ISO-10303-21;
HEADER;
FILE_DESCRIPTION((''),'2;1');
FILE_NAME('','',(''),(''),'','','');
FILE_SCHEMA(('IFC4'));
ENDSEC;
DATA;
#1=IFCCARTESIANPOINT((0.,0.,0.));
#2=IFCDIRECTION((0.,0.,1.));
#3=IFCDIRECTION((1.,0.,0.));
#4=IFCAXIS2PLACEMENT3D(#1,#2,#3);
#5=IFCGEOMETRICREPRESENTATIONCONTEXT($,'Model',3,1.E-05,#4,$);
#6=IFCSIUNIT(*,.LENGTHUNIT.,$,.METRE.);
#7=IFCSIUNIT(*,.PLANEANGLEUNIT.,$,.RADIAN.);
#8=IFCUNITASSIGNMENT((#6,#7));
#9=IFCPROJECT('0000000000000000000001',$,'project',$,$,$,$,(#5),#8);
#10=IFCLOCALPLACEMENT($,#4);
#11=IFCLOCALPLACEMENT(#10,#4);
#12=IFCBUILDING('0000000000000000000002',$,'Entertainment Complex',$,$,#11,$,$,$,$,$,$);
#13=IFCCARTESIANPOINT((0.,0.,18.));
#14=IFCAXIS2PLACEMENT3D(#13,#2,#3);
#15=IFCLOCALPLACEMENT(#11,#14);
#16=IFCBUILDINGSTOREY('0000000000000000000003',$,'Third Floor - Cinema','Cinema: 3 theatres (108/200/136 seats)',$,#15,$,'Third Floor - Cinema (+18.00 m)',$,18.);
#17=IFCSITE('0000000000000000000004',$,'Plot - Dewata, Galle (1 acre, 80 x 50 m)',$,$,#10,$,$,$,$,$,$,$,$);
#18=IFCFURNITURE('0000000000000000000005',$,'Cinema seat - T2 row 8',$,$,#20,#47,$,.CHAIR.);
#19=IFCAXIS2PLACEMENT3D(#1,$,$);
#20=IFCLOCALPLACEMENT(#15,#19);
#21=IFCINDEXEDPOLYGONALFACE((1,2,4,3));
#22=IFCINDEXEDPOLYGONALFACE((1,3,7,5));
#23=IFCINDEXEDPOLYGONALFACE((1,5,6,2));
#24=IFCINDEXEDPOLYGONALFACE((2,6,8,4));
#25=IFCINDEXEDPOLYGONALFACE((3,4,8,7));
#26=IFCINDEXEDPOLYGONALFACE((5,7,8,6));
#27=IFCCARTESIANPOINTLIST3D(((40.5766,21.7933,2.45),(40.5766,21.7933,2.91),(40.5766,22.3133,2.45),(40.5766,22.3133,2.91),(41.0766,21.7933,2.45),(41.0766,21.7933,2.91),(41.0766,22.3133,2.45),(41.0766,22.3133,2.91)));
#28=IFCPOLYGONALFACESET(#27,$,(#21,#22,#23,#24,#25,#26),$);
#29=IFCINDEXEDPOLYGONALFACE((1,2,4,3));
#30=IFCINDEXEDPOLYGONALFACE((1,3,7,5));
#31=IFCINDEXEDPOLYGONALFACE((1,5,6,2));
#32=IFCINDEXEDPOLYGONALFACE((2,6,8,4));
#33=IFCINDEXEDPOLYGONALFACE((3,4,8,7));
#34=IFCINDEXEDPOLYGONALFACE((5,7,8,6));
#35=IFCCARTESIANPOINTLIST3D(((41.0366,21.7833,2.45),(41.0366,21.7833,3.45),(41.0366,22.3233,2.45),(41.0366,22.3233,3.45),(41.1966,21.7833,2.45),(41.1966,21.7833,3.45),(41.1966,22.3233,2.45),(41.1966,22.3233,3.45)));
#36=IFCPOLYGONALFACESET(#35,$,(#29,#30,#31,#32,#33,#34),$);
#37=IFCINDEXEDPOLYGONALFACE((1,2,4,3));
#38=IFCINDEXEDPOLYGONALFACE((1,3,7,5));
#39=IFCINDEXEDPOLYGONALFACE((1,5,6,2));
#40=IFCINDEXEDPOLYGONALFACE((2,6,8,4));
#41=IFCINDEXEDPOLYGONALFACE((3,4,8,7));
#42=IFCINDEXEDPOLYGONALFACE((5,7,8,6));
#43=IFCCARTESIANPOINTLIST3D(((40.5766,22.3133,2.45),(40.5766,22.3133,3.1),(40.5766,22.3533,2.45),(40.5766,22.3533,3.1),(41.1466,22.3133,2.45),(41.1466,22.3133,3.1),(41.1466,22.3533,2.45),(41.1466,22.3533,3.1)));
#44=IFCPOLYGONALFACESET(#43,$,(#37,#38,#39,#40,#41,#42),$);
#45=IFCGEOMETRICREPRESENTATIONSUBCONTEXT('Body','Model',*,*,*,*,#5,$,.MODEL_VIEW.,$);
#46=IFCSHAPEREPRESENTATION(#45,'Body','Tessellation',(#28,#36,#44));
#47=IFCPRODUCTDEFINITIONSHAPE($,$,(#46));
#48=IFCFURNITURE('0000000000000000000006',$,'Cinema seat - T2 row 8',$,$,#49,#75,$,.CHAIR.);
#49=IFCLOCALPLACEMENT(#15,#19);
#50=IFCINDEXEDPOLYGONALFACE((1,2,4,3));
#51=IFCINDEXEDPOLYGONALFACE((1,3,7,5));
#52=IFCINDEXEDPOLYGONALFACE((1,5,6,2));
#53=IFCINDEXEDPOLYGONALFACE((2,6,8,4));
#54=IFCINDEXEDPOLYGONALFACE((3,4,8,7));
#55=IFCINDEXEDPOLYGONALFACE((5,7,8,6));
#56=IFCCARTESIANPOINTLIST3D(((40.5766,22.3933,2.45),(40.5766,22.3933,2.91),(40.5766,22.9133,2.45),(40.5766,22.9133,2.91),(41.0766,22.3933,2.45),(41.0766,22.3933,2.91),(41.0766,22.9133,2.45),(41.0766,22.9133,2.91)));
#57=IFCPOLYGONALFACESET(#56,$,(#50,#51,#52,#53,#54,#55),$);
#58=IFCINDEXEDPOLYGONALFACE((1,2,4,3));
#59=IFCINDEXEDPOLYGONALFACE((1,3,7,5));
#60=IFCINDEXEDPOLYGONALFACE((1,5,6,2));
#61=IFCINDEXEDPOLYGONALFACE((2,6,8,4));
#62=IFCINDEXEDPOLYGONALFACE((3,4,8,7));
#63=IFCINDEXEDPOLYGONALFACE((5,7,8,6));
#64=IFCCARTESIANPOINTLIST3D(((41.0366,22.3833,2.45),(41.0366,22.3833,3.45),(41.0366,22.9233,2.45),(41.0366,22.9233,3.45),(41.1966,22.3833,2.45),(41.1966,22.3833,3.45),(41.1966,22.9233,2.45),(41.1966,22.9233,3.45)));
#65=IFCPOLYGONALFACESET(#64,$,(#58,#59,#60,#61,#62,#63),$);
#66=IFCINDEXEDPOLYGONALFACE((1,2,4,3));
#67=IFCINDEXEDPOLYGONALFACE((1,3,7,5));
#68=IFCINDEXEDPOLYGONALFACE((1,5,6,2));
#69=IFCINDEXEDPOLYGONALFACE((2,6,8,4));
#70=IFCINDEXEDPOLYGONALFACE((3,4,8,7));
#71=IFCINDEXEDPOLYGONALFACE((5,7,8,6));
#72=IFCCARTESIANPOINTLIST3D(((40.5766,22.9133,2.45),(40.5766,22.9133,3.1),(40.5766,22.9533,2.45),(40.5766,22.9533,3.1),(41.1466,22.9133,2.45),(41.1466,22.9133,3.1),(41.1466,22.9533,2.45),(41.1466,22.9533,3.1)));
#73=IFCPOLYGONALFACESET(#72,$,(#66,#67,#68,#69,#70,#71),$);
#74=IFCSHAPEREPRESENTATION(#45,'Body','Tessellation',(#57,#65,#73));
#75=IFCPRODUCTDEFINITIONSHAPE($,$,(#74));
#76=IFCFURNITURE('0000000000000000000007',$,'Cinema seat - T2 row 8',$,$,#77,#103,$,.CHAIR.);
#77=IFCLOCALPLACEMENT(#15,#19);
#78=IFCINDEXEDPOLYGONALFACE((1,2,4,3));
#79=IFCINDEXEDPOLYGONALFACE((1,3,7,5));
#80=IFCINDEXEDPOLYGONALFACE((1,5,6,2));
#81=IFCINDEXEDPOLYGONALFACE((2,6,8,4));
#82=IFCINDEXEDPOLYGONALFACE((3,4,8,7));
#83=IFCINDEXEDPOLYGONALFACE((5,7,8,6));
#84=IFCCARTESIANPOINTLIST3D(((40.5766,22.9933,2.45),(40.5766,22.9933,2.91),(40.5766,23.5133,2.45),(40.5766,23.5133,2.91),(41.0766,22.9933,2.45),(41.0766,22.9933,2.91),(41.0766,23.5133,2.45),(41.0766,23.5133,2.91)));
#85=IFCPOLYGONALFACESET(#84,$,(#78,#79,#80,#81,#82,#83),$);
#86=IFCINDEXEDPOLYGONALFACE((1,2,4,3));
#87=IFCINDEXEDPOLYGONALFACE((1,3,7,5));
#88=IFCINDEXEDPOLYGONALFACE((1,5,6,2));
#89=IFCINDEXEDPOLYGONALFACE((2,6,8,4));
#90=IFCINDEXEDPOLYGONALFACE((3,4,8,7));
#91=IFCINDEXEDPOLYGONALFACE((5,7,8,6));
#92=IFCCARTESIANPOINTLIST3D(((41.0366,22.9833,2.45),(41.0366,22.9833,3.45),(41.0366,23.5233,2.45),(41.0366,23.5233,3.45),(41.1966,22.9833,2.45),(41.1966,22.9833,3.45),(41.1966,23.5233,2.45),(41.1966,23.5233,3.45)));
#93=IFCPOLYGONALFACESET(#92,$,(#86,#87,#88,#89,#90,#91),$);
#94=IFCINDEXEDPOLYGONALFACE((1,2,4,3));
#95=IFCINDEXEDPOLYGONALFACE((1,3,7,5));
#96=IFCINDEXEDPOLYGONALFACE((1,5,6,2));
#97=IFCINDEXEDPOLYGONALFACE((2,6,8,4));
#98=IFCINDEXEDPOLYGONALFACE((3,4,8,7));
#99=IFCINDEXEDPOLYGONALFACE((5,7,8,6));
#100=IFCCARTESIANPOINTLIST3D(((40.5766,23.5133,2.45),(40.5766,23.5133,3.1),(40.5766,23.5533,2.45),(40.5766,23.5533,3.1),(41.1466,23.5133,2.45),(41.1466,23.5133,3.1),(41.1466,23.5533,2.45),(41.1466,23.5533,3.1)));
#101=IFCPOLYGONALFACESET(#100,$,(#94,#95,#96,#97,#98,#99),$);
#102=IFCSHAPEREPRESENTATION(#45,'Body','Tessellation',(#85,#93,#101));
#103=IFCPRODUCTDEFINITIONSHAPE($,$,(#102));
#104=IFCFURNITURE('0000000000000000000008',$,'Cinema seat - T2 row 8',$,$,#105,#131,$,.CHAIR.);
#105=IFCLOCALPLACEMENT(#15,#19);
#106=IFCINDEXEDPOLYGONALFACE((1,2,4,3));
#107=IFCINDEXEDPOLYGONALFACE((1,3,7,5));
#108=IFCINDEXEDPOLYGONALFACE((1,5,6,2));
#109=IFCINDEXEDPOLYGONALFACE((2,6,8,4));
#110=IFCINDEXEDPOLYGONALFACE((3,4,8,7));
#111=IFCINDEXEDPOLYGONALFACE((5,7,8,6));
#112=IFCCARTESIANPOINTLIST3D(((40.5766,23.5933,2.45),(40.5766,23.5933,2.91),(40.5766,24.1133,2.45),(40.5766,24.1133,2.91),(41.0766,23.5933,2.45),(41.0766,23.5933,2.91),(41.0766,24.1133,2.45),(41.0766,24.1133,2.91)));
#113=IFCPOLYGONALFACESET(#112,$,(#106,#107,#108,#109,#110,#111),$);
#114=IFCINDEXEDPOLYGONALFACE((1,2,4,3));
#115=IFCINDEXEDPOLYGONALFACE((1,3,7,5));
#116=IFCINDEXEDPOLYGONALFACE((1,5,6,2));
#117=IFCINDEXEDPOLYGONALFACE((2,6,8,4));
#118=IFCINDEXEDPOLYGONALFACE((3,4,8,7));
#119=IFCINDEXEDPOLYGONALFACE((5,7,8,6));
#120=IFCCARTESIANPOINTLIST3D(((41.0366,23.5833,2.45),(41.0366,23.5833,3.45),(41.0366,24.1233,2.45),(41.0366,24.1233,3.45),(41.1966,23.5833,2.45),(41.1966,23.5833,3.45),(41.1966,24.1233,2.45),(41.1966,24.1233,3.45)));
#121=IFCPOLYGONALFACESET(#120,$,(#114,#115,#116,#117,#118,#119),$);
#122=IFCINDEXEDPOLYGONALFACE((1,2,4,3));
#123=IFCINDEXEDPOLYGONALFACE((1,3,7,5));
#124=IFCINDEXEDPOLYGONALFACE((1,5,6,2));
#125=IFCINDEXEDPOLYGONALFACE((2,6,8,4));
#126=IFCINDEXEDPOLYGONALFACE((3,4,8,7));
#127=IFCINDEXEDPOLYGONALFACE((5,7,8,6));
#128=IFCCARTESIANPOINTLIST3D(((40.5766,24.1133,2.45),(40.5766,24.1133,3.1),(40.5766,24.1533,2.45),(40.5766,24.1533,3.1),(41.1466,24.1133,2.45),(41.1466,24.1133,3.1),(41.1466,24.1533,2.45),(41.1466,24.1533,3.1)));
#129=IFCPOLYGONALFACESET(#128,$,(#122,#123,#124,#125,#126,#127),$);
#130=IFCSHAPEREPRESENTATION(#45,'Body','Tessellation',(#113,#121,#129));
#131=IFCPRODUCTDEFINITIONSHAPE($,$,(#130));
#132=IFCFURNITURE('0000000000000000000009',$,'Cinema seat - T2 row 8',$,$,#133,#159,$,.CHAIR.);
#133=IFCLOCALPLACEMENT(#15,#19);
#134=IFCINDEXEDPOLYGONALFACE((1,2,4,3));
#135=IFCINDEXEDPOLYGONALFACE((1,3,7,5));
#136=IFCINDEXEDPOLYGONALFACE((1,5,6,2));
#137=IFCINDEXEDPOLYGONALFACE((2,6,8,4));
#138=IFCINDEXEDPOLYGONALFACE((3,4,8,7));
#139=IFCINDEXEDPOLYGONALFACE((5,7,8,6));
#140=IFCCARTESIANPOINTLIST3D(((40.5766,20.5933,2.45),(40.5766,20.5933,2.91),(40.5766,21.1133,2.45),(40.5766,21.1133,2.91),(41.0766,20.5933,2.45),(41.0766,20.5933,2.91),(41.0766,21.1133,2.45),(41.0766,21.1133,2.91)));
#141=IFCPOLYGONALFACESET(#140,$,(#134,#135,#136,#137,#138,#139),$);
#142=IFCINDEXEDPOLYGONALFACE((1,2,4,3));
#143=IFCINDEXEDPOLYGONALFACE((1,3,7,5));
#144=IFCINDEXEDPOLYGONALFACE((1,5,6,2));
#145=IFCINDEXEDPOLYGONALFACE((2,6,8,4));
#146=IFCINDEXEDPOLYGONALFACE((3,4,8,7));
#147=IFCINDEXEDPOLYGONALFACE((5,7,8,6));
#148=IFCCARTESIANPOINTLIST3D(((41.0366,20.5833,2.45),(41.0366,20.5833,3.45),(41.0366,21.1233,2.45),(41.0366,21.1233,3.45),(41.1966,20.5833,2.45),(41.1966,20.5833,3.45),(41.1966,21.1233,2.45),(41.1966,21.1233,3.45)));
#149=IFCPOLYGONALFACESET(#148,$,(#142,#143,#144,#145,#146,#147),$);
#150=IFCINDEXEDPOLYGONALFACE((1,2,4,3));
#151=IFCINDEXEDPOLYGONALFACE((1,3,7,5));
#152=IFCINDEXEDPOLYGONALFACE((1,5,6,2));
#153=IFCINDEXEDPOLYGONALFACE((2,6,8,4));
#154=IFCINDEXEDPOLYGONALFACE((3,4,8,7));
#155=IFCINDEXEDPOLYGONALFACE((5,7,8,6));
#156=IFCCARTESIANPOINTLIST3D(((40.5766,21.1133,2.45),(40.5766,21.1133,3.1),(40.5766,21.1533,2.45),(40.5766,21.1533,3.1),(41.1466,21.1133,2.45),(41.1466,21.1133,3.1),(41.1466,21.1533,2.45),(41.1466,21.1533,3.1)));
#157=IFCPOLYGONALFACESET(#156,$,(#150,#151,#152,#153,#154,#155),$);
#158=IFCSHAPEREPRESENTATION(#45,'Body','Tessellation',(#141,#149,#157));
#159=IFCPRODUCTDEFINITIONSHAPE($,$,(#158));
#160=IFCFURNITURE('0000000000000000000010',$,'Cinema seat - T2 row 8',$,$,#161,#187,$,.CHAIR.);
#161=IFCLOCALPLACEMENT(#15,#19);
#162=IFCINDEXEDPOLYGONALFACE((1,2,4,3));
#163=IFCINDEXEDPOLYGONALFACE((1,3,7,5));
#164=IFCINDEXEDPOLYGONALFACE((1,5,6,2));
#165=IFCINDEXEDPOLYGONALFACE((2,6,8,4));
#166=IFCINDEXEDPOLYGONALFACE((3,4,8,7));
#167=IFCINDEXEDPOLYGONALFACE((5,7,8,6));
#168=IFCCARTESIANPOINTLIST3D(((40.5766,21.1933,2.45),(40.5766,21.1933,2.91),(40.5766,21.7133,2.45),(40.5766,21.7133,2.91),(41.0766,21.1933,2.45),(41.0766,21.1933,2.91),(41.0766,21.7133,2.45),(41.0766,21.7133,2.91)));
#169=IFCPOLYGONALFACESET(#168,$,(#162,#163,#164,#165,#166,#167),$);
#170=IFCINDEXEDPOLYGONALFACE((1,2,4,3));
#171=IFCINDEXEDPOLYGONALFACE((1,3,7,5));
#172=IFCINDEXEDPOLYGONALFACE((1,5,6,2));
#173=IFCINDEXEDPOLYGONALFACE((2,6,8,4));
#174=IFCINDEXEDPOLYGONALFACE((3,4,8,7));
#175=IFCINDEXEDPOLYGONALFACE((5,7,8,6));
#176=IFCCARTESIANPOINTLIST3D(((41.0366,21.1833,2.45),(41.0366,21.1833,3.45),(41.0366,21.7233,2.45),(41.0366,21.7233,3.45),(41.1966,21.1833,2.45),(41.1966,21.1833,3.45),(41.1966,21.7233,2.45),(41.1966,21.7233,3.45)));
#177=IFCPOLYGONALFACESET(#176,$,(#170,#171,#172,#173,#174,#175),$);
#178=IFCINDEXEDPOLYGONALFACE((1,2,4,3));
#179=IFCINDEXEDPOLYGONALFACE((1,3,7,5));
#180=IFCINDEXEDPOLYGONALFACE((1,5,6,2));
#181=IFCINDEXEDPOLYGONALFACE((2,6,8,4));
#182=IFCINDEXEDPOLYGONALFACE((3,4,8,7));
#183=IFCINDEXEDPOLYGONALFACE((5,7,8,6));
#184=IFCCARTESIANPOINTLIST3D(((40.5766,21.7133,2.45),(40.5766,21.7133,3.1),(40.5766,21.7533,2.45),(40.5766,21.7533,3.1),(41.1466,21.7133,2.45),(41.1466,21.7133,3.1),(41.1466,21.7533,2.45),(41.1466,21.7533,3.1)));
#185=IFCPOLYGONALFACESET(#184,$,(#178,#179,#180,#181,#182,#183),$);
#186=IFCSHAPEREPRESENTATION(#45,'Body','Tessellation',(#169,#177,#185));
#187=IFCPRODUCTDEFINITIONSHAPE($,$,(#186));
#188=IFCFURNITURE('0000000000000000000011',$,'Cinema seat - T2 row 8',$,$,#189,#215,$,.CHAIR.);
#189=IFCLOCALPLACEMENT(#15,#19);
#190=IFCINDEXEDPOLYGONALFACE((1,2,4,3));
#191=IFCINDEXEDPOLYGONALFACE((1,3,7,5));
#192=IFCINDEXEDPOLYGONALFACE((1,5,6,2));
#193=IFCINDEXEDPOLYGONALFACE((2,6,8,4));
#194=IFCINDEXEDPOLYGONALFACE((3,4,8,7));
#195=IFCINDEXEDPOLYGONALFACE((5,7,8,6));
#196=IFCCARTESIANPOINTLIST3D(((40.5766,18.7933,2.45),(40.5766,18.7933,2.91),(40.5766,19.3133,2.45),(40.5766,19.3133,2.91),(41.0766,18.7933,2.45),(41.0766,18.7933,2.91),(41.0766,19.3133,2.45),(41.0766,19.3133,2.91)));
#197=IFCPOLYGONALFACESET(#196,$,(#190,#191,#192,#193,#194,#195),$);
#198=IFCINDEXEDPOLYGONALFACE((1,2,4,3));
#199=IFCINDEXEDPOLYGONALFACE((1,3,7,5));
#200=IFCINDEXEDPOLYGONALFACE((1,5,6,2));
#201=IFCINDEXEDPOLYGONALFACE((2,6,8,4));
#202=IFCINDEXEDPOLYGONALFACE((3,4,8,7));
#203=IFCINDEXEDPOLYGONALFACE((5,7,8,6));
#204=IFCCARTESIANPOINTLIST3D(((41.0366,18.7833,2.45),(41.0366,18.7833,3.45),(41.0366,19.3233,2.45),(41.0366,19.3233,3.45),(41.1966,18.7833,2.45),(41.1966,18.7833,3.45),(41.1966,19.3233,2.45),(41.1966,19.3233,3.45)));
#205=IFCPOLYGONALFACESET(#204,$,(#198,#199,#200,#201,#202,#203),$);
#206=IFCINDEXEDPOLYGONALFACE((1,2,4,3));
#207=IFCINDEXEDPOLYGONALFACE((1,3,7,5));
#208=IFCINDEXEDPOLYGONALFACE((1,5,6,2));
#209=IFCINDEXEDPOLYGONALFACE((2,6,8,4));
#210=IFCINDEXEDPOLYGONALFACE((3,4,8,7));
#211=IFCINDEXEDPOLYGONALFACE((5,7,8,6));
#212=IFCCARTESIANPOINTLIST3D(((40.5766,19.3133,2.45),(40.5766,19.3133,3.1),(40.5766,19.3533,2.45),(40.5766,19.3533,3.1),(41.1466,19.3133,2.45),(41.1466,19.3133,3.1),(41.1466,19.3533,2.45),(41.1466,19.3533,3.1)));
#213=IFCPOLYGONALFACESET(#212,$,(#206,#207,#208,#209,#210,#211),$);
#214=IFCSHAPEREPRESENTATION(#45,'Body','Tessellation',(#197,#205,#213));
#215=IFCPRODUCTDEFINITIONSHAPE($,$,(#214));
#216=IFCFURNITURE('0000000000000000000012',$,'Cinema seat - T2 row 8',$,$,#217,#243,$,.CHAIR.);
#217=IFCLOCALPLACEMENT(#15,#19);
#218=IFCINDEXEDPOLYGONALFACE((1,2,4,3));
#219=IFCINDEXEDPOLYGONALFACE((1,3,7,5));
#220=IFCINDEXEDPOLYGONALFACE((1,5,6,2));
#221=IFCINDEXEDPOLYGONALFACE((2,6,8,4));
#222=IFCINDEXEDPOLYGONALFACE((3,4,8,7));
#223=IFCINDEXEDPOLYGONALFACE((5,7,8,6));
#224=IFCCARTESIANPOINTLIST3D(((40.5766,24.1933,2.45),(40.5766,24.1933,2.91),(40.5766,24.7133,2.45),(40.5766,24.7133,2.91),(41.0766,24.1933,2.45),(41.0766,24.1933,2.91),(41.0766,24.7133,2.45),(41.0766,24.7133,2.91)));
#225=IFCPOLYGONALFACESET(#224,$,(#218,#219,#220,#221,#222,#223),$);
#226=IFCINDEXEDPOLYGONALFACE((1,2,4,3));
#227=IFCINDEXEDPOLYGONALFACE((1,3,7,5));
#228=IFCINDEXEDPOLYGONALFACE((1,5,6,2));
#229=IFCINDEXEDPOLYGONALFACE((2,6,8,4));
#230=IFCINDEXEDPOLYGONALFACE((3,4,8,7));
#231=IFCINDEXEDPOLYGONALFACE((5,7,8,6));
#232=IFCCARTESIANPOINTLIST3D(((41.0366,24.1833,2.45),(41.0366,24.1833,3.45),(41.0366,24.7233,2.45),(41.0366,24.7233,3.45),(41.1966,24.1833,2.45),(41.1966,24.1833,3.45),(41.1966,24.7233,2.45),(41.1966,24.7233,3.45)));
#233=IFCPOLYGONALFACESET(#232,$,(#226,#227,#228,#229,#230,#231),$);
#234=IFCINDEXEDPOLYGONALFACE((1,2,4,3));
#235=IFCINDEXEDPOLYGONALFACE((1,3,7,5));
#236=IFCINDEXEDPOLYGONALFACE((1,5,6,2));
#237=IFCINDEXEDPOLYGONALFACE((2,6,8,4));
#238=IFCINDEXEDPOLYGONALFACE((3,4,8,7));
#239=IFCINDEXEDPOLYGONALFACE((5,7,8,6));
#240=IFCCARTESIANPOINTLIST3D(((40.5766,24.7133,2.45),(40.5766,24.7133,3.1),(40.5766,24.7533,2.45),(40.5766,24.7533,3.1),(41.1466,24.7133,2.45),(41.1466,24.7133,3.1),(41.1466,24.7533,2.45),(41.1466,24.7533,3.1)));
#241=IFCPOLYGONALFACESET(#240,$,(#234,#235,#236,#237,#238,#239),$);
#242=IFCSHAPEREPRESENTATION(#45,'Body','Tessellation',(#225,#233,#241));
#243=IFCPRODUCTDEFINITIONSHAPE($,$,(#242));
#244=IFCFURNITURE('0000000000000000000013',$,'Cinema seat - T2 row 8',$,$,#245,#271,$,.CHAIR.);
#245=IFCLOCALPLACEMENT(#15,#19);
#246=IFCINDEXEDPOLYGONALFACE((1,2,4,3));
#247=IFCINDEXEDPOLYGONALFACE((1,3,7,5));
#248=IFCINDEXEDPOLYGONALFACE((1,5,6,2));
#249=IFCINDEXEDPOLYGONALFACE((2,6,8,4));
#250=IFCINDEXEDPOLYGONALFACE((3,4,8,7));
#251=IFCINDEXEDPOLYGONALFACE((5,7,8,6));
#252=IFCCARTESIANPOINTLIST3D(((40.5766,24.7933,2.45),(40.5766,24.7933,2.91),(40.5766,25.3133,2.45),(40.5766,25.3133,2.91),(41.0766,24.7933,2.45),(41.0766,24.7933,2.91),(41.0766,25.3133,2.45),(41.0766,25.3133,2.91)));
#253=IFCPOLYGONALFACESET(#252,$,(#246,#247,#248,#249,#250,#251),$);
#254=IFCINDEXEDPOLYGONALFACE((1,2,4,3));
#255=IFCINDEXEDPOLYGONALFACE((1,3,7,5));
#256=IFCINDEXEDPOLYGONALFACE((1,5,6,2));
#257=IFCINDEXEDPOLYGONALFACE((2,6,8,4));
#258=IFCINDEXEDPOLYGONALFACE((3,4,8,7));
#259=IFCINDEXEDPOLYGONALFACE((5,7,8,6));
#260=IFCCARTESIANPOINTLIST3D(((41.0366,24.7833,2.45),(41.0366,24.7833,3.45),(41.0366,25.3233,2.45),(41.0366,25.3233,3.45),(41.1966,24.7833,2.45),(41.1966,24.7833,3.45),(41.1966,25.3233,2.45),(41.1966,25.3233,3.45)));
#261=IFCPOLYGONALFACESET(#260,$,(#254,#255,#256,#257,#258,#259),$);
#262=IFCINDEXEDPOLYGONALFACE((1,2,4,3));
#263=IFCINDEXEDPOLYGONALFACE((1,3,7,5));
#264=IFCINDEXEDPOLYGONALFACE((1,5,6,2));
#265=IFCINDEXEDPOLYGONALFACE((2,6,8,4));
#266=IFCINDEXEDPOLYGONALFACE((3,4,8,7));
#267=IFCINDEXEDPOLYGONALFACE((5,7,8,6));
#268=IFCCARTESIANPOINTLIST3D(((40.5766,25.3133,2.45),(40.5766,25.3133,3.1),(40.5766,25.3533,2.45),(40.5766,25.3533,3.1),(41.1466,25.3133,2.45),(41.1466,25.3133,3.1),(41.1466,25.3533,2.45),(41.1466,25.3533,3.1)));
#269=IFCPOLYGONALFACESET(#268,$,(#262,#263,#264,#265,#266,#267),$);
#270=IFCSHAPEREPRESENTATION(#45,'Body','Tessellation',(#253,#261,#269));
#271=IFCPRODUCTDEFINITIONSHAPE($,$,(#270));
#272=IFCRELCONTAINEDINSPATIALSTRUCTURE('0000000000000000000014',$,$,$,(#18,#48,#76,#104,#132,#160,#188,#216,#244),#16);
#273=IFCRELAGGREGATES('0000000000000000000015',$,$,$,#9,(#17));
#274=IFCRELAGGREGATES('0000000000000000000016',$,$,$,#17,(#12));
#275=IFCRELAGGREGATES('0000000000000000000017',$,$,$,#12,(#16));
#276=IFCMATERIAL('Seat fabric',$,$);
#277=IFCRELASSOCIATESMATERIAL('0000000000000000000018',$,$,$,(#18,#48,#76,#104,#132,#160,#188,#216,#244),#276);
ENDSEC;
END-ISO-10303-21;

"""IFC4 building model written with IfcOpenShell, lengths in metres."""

from ifc_helpers import new_model, si_unit, frame, origin_with_axes, place, context, subcontext, project, spatial, polyline, outline, extrude, material, element, save


model = new_model("IFC4")

# Units and contexts
model_context = context("Model", 3, precision=1e-05, world=origin_with_axes())
body_context = subcontext(model_context, "Body", "Model", "MODEL_VIEW")
ifc_project = project(units=[si_unit("LENGTHUNIT", "METRE"), si_unit("PLANEANGLEUNIT", "RADIAN")], contexts=[model_context])

# Site, building, storey
site_placement = place(None, origin_with_axes())
site = spatial("IfcSite", under=ifc_project, at=site_placement, Name="Plot - Dewata, Galle (1 acre, 80 x 50 m)")
building_placement = place(site_placement, origin_with_axes())
building = spatial("IfcBuilding", under=site, at=building_placement, Name="Entertainment Complex")
storey_placement = place(building_placement, frame((0.0, 0.0, 18.0), z_axis=(0.0, 0.0, 1.0), x_axis=(1.0, 0.0, 0.0)))
storey = spatial("IfcBuildingStorey", under=building, at=storey_placement, Name="Third Floor - Cinema", Description="Cinema: 3 theatres (108/200/136 seats)", LongName="Third Floor - Cinema (+18.00 m)", Elevation=18.0)

# Furniture
ifc_material_1 = material(Name="Seat fabric")
for number, where, z_axis, x_axis, name in (
    (1, (41.1966, 22.0533, 2.45), (0.0, 0.0, 1.0), (1.0, 0.0, 0.0), "Cinema seat - T2 row 8"),
    (2, (41.1966, 22.6533, 2.45), (0.0, 0.0, 1.0), (1.0, 0.0, 0.0), "Cinema seat - T2 row 8"),
    (3, (41.1966, 23.2533, 2.45), (0.0, 0.0, 1.0), (1.0, 0.0, 0.0), "Cinema seat - T2 row 8"),
    (4, (41.1966, 23.8533, 2.45), (0.0, 0.0, 1.0), (1.0, 0.0, 0.0), "Cinema seat - T2 row 8"),
    (5, (41.1966, 20.8533, 2.45), (0.0, 0.0, 1.0), (1.0, 0.0, 0.0), "Cinema seat - T2 row 8"),
    (6, (41.1966, 21.4533, 2.45), (0.0, 0.0, 1.0), (1.0, 0.0, 0.0), "Cinema seat - T2 row 8"),
    (7, (41.1966, 19.0533, 2.45), (0.0, 0.0, 1.0), (1.0, 0.0, 0.0), "Cinema seat - T2 row 8"),
    (8, (41.1966, 24.4533, 2.45), (0.0, 0.0, 1.0), (1.0, 0.0, 0.0), "Cinema seat - T2 row 8"),
    (9, (41.1966, 25.0533, 2.45), (0.0, 0.0, 1.0), (1.0, 0.0, 0.0), "Cinema seat - T2 row 8"),
):
    element("IfcFurniture", number, at=place(storey_placement, frame(where, z_axis=z_axis, x_axis=x_axis)), inside=storey, material=ifc_material_1, Name=name, PredefinedType="CHAIR", context=body_context, shape_type="SweptSolid", body=[
        extrude(outline(polyline([(-0.62, -0.26), (-0.12, -0.26), (-0.12, 0.26), (-0.62, 0.26), (-0.62, -0.26)])), origin_with_axes(), (0.0, 0.0, 1.0), 0.46),
        extrude(outline(polyline([(-0.16, -0.27), (0.0, -0.27), (0.0, 0.27), (-0.16, 0.27), (-0.16, -0.27)])), origin_with_axes(), (0.0, 0.0, 1.0), 1.0),
        extrude(outline(polyline([(-0.62, 0.26), (-0.05, 0.26), (-0.05, 0.3), (-0.62, 0.3), (-0.62, 0.26)])), origin_with_axes(), (0.0, 0.0, 1.0), 0.65),
    ])

save(model, "model.ifc")
